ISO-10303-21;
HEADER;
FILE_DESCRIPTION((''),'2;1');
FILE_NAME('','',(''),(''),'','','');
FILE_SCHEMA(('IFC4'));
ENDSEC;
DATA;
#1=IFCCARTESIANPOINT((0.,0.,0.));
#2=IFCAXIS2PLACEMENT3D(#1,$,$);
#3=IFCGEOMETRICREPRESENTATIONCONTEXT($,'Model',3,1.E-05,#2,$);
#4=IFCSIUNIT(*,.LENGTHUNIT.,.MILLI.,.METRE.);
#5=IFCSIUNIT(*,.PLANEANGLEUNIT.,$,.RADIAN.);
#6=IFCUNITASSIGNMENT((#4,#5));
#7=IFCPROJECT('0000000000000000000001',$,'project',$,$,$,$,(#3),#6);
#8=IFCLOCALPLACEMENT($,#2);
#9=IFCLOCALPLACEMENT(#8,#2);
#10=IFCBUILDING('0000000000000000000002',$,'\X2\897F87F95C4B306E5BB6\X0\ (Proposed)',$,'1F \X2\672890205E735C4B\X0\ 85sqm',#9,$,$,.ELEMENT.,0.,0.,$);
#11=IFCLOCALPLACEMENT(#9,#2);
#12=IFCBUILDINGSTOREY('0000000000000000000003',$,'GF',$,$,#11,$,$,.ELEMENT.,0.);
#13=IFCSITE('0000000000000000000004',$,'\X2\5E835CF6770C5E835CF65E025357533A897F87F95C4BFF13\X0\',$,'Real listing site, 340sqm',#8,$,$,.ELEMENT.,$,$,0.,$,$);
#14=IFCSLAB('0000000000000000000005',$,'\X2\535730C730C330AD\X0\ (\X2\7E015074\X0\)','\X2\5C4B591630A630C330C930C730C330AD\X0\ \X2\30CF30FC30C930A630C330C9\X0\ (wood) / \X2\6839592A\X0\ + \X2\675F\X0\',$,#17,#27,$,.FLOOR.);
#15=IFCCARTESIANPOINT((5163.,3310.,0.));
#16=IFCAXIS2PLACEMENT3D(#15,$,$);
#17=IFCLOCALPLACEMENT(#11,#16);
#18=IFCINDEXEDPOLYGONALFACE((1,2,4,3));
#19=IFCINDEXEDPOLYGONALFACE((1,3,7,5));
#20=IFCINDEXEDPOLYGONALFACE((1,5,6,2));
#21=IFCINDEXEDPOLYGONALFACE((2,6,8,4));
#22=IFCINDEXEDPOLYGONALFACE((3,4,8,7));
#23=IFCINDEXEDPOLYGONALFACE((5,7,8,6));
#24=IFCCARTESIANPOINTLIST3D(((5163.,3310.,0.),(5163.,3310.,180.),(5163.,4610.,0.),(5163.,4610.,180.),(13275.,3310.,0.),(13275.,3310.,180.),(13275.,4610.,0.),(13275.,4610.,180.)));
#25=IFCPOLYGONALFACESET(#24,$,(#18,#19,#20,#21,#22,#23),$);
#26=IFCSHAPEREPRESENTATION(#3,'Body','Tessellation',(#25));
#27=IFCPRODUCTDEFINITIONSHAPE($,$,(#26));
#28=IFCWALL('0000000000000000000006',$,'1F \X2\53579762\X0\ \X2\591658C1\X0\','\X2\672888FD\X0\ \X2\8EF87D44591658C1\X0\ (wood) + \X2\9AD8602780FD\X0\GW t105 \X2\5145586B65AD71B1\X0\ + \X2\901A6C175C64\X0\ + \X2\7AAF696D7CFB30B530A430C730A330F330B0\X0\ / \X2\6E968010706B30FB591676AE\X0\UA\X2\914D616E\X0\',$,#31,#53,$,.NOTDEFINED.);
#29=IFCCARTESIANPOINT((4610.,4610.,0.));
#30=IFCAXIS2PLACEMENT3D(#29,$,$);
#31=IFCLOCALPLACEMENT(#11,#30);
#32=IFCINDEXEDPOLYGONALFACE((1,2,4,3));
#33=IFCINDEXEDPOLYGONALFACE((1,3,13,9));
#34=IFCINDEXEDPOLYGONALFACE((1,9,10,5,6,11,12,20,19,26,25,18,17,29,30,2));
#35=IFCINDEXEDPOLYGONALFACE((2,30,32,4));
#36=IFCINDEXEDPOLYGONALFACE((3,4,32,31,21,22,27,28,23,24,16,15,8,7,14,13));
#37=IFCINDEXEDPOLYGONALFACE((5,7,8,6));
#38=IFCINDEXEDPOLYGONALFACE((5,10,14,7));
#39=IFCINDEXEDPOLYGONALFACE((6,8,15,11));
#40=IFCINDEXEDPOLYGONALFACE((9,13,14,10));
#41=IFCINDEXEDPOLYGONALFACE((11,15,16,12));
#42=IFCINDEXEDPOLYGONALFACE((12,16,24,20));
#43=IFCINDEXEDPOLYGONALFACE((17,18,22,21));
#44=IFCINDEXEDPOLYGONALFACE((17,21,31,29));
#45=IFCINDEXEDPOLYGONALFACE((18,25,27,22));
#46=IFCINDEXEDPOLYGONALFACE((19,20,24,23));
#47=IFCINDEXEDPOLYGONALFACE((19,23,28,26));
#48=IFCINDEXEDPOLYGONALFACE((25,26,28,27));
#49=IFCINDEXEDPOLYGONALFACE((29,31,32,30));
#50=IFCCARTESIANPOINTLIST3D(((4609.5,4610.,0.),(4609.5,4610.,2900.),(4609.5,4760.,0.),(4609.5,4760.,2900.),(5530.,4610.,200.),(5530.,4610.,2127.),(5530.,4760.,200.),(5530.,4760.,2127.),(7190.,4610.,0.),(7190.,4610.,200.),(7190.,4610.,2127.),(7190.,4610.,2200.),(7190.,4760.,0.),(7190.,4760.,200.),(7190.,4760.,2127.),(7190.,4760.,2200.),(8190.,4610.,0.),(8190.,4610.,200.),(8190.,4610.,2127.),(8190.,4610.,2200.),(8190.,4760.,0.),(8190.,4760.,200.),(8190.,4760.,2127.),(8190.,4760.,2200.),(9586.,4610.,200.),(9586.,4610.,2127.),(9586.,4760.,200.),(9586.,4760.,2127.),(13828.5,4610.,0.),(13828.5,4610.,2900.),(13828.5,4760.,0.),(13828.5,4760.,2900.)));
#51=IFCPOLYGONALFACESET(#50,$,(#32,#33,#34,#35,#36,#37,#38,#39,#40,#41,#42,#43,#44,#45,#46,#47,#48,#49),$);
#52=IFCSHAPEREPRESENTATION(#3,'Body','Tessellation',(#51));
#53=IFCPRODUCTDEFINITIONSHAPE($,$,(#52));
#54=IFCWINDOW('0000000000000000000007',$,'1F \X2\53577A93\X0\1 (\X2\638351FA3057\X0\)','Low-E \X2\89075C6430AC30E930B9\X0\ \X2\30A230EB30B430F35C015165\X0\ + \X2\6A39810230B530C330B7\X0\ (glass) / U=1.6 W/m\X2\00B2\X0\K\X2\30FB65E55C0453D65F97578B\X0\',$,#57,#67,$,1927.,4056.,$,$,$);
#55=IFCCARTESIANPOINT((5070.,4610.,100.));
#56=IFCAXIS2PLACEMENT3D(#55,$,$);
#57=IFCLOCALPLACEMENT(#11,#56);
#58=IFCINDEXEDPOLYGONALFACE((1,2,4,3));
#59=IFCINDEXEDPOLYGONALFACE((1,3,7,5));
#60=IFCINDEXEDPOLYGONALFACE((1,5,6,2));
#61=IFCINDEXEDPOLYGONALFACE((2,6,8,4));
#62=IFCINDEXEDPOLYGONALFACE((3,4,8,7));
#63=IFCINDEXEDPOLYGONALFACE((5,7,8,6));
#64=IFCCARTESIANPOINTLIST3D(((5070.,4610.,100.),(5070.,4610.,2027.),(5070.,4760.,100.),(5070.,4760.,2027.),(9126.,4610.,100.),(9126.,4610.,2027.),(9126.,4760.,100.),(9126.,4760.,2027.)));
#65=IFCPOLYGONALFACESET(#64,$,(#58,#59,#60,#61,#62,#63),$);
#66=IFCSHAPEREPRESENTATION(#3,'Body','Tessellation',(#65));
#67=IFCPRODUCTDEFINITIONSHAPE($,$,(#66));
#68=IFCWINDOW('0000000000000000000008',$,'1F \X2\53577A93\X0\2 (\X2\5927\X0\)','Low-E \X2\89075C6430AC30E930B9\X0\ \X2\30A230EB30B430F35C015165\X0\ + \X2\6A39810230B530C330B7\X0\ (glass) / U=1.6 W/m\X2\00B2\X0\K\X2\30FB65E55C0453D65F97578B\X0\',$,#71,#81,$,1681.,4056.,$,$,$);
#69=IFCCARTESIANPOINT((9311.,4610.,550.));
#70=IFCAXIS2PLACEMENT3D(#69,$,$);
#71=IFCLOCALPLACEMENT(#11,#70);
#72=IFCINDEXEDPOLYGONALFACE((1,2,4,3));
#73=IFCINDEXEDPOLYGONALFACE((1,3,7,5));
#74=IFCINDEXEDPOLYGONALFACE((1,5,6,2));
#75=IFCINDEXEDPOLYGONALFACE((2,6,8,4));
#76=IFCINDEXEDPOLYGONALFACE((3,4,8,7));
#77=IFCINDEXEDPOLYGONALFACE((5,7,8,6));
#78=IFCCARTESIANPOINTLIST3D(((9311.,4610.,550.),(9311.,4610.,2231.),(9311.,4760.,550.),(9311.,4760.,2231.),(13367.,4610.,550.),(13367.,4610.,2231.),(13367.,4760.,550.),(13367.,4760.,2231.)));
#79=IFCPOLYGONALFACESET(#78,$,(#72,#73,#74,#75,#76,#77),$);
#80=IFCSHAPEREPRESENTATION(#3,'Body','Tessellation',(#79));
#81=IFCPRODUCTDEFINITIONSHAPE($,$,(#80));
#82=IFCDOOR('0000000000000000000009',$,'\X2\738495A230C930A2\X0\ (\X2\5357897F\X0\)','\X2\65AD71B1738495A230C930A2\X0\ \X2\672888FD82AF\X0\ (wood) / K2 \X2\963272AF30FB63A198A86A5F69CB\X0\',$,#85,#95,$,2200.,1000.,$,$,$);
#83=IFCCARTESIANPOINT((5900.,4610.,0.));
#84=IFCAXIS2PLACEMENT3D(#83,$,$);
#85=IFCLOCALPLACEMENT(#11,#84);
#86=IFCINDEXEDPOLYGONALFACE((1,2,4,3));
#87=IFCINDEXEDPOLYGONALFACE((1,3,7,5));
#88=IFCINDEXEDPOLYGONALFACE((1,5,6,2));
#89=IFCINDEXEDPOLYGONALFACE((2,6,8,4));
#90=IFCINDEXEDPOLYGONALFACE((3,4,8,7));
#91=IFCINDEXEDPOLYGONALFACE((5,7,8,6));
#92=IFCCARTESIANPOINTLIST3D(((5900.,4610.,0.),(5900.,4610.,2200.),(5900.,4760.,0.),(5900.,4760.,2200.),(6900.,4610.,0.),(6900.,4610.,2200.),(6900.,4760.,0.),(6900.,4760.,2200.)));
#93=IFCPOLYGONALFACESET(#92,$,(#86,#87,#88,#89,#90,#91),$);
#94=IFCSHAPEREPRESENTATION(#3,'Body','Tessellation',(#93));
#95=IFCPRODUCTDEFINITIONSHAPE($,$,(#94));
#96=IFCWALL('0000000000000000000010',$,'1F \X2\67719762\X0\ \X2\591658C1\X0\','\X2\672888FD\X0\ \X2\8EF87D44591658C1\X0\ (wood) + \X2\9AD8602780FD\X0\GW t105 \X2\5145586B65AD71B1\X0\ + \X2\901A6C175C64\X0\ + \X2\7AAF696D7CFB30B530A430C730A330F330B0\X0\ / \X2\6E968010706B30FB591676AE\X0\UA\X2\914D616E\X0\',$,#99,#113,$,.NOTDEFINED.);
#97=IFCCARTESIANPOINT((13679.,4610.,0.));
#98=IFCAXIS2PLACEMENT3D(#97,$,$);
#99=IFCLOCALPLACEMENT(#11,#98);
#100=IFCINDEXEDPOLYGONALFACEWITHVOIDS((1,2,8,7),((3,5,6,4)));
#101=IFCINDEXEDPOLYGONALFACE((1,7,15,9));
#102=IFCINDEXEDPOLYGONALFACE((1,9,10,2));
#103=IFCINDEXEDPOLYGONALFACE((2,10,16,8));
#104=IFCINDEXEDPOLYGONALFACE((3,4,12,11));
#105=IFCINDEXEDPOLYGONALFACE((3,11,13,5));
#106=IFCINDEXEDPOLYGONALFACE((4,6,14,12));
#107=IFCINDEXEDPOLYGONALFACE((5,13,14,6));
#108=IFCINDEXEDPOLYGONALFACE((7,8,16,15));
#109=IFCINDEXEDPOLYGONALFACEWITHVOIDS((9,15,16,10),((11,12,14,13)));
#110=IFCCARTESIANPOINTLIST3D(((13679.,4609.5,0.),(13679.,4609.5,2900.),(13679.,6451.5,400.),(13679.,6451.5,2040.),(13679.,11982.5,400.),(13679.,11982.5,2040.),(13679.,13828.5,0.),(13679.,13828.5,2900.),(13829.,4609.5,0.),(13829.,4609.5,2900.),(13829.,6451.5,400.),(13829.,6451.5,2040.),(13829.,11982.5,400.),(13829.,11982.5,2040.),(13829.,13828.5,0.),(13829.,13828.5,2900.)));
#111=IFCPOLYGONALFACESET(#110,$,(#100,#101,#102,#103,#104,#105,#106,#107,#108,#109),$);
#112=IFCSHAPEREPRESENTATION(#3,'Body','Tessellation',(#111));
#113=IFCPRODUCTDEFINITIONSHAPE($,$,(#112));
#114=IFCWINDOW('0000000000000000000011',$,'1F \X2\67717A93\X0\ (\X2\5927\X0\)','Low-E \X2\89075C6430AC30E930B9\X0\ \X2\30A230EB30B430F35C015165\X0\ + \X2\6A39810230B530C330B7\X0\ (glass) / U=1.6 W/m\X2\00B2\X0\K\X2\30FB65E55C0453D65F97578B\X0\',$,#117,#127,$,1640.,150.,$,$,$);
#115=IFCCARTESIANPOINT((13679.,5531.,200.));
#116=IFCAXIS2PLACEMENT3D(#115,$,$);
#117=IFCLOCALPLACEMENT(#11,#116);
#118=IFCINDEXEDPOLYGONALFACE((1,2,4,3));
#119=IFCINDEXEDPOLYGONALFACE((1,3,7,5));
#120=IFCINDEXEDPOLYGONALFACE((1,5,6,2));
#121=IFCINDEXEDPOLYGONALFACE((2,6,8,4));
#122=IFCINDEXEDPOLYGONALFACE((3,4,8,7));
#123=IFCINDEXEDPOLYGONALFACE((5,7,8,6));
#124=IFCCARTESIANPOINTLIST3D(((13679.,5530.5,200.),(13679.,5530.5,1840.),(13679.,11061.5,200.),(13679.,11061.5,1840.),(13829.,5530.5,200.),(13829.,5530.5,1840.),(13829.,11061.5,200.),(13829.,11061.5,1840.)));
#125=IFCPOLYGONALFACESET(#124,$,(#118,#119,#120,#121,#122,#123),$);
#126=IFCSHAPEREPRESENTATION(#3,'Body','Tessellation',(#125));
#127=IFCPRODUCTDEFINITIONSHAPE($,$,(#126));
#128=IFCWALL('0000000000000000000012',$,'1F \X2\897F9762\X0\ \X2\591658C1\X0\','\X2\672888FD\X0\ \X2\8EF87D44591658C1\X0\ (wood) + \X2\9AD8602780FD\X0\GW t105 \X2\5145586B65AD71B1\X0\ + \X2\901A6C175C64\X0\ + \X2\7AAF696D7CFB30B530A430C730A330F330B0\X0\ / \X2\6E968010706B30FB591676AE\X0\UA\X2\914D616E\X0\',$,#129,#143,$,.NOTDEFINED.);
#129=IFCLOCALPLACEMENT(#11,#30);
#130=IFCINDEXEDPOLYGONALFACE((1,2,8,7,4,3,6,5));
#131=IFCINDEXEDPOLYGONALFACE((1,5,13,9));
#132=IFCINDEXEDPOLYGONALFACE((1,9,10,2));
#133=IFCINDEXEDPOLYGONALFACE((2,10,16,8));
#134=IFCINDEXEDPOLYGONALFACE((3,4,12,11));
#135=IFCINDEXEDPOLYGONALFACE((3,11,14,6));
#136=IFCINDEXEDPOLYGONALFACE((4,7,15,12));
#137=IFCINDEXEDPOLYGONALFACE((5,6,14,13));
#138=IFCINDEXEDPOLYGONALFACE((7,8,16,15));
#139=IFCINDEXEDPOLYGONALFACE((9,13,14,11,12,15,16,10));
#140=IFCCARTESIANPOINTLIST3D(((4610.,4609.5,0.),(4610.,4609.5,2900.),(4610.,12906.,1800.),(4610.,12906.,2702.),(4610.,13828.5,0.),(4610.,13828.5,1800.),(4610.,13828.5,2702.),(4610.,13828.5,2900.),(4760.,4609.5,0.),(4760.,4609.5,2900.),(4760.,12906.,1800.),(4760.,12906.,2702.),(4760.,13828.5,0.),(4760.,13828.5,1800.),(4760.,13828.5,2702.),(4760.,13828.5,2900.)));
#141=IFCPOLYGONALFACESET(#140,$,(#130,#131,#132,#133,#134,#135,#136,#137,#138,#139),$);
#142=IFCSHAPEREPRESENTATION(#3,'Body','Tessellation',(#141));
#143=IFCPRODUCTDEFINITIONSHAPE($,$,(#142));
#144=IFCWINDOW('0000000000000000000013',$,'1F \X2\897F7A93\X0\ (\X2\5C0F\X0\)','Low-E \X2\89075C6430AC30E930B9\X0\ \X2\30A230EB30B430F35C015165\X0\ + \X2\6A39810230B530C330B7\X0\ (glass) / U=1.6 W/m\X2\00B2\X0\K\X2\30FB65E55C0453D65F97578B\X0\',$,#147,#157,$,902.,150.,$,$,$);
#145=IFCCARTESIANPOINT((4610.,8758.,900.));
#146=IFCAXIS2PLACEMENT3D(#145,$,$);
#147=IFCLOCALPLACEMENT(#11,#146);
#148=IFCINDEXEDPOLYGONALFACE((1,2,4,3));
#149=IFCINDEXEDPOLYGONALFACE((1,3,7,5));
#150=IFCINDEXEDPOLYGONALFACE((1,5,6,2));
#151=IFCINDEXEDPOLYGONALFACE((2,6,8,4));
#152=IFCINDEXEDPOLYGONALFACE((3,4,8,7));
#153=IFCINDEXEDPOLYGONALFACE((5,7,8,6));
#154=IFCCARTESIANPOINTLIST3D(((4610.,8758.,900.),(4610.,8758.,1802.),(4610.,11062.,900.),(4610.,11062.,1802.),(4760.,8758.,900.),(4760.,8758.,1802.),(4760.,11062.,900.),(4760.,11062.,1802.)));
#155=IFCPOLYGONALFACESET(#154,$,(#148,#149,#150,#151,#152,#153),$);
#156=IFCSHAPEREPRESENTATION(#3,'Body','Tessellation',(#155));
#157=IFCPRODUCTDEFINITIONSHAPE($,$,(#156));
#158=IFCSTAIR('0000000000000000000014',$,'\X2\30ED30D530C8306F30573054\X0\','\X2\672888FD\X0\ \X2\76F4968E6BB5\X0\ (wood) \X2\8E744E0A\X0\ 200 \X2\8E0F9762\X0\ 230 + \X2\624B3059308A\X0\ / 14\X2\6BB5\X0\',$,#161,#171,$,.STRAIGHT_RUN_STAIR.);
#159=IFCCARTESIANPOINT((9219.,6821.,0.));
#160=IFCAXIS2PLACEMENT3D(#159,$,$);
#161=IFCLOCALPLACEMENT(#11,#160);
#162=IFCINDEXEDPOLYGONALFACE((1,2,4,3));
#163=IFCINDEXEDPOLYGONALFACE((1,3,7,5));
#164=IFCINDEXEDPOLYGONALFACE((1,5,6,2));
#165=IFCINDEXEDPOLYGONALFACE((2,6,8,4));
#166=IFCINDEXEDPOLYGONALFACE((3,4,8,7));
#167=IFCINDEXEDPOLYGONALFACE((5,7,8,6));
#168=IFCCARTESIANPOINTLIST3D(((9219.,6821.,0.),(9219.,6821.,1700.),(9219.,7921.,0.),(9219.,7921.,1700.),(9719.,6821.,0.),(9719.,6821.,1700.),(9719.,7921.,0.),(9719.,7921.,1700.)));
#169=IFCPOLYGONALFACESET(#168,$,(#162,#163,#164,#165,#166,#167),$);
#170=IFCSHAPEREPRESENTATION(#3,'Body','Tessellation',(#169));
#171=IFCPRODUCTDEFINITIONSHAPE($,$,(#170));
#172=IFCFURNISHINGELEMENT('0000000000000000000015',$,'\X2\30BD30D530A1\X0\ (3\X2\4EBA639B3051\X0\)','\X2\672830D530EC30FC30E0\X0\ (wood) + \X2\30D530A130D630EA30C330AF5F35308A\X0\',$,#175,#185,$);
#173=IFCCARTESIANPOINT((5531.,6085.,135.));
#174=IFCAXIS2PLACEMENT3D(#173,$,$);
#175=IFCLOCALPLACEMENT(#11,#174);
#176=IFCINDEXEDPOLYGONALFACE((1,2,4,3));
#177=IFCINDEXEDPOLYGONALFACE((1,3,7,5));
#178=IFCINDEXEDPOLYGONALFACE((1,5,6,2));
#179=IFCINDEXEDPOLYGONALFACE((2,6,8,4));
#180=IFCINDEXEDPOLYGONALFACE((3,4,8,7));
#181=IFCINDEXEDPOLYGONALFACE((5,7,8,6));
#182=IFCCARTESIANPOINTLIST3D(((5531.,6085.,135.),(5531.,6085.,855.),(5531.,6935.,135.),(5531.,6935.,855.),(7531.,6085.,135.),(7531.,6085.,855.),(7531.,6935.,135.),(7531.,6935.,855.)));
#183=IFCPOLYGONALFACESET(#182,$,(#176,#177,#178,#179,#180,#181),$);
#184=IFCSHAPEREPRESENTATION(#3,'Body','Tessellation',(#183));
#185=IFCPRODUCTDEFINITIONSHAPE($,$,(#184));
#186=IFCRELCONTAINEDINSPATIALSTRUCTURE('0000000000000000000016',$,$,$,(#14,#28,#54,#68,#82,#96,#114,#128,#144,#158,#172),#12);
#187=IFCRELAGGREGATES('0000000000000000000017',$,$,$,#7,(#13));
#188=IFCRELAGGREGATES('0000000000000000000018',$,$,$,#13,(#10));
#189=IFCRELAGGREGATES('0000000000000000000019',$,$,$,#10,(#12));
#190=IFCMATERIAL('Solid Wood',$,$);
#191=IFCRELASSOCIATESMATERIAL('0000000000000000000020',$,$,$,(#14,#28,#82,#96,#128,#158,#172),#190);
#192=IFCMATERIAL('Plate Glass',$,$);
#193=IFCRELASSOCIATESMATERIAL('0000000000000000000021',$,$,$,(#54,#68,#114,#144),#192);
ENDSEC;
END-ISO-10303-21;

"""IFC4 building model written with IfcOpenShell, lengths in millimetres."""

from ifc_helpers import new_model, si_unit, frame, frame_2d, origin, place, context, project, spatial, rectangle, extrude, material, element, fill, save


model = new_model("IFC4")

# Units and contexts
model_context = context("Model", 3, precision=1e-05, world=origin())
ifc_project = project(units=[si_unit("LENGTHUNIT", "METRE", prefix="MILLI"), si_unit("PLANEANGLEUNIT", "RADIAN")], contexts=[model_context])

# Site, building, storey
site_placement = place(None, origin())
site = spatial("IfcSite", under=ifc_project, at=site_placement, Name="広島県広島市南区西蟹屋３", ObjectType="Real listing site, 340sqm", CompositionType="ELEMENT", RefElevation=0.0)
building_placement = place(site_placement, origin())
building = spatial("IfcBuilding", under=site, at=building_placement, Name="西蟹屋の家 (Proposed)", ObjectType="1F 木造平屋 85sqm", CompositionType="ELEMENT", ElevationOfRefHeight=0.0, ElevationOfTerrain=0.0)
storey_placement = place(building_placement, origin())
storey = spatial("IfcBuildingStorey", under=building, at=storey_placement, Name="GF", CompositionType="ELEMENT", Elevation=0.0)

# Slab
ifc_material_1 = material(Name="Solid Wood")
slab_1_placement = place(storey_placement, frame((5163.0, 3310.0, 0.0)))
element("IfcSlab", 1, at=slab_1_placement, inside=storey, material=ifc_material_1, Name="南デッキ (縁側)", Description="屋外ウッドデッキ ハードウッド (wood) / 根太 + 束", PredefinedType="FLOOR", context=model_context, shape_type="SweptSolid", body=[
    extrude(rectangle(XDim=8112.0, YDim=1300.0, at=frame_2d((4056.0, 650.0))), frame((5163.0, 3310.0, 0.0)), (0.0, 0.0, 1.0), 180.0),
])

# Wall, openings, windows, door
wall_1_placement = place(storey_placement, frame((4610.0, 4610.0, 0.0)))
wall_1 = element("IfcWall", 2, at=wall_1_placement, inside=storey, material=ifc_material_1, Name="1F 南面 外壁", Description="木製 軸組外壁 (wood) + 高性能GW t105 充填断熱 + 通気層 + 窯業系サイディング / 準耐火・外皮UA配慮", PredefinedType="NOTDEFINED", context=model_context, shape_type="SweptSolid", body=[
    extrude(rectangle(XDim=9219.0, YDim=150.0, at=frame_2d((4609.0, 75.0))), frame((4610.0, 4610.0, 0.0)), (0.0, 0.0, 1.0), 2900.0),
])
opening_1_placement = place(storey_placement, frame((5070.0, 4610.0, 100.0)))
opening_1 = element("IfcOpeningElement", 3, at=opening_1_placement, cuts=wall_1, PredefinedType="NOTDEFINED", context=model_context, shape_type="SweptSolid", body=[
    extrude(rectangle(XDim=4056.0, YDim=150.0, at=frame_2d((2028.0, 75.0))), frame((5070.0, 4610.0, 100.0)), (0.0, 0.0, 1.0), 1927.0),
])
opening_2_placement = place(storey_placement, frame((9311.0, 4610.0, 550.0)))
opening_2 = element("IfcOpeningElement", 4, at=opening_2_placement, cuts=wall_1, PredefinedType="NOTDEFINED", context=model_context, shape_type="SweptSolid", body=[
    extrude(rectangle(XDim=4056.0, YDim=150.0, at=frame_2d((2028.0, 75.0))), frame((9311.0, 4610.0, 550.0)), (0.0, 0.0, 1.0), 1681.0),
])
opening_3_placement = place(storey_placement, frame((5900.0, 4610.0, 0.0)))
opening_3 = element("IfcOpeningElement", 5, at=opening_3_placement, cuts=wall_1, PredefinedType="NOTDEFINED", context=model_context, shape_type="SweptSolid", body=[
    extrude(rectangle(XDim=1000.0, YDim=150.0, at=frame_2d((500.0, 75.0))), frame((5900.0, 4610.0, 0.0)), (0.0, 0.0, 1.0), 2200.0),
])
ifc_material_2 = material(Name="Plate Glass")
window_1_placement = place(storey_placement, frame((5070.0, 4610.0, 100.0)))
window_1 = element("IfcWindow", 6, at=window_1_placement, inside=storey, material=ifc_material_2, Name="1F 南窓1 (掃出し)", Description="Low-E 複層ガラス アルゴン封入 + 樹脂サッシ (glass) / U=1.6 W/m²K・日射取得型", OverallHeight=1927.0, OverallWidth=4056.0, context=model_context, shape_type="SweptSolid", body=[
    extrude(rectangle(XDim=4056.0, YDim=150.0, at=frame_2d((2028.0, 75.0))), frame((5070.0, 4610.0, 100.0)), (0.0, 0.0, 1.0), 1927.0),
])
fill(opening_1, window_1)
window_2_placement = place(storey_placement, frame((9311.0, 4610.0, 550.0)))
window_2 = element("IfcWindow", 7, at=window_2_placement, inside=storey, material=ifc_material_2, Name="1F 南窓2 (大)", Description="Low-E 複層ガラス アルゴン封入 + 樹脂サッシ (glass) / U=1.6 W/m²K・日射取得型", OverallHeight=1681.0, OverallWidth=4056.0, context=model_context, shape_type="SweptSolid", body=[
    extrude(rectangle(XDim=4056.0, YDim=150.0, at=frame_2d((2028.0, 75.0))), frame((9311.0, 4610.0, 550.0)), (0.0, 0.0, 1.0), 1681.0),
])
fill(opening_2, window_2)
door_placement = place(storey_placement, frame((5900.0, 4610.0, 0.0)))
door = element("IfcDoor", 8, at=door_placement, inside=storey, material=ifc_material_1, Name="玄関ドア (南西)", Description="断熱玄関ドア 木製芯 (wood) / K2 防犯・採風機構", OverallHeight=2200.0, OverallWidth=1000.0, context=model_context, shape_type="SweptSolid", body=[
    extrude(rectangle(XDim=1000.0, YDim=150.0, at=frame_2d((500.0, 75.0))), frame((5900.0, 4610.0, 0.0)), (0.0, 0.0, 1.0), 2200.0),
])
fill(opening_3, door)

# Walls, openings, windows
wall_2_placement = place(storey_placement, frame((13679.0, 4610.0, 0.0)))
wall_2 = element("IfcWall", 9, at=wall_2_placement, inside=storey, material=ifc_material_1, Name="1F 東面 外壁", Description="木製 軸組外壁 (wood) + 高性能GW t105 充填断熱 + 通気層 + 窯業系サイディング / 準耐火・外皮UA配慮", PredefinedType="NOTDEFINED", context=model_context, shape_type="SweptSolid", body=[
    extrude(rectangle(XDim=150.0, YDim=9219.0, at=frame_2d((75.0, 4609.0))), frame((13679.0, 4610.0, 0.0)), (0.0, 0.0, 1.0), 2900.0),
])
opening_4_placement = place(storey_placement, frame((13679.0, 5531.0, 200.0)))
opening_4 = element("IfcOpeningElement", 10, at=opening_4_placement, cuts=wall_2, PredefinedType="NOTDEFINED", context=model_context, shape_type="SweptSolid", body=[
    extrude(rectangle(XDim=150.0, YDim=5531.0, at=frame_2d((75.0, 2765.0))), frame((13679.0, 5531.0, 200.0)), (0.0, 0.0, 1.0), 1640.0),
])
window_3_placement = place(storey_placement, frame((13679.0, 5531.0, 200.0)))
window_3 = element("IfcWindow", 11, at=window_3_placement, inside=storey, material=ifc_material_2, Name="1F 東窓 (大)", Description="Low-E 複層ガラス アルゴン封入 + 樹脂サッシ (glass) / U=1.6 W/m²K・日射取得型", OverallHeight=1640.0, OverallWidth=150.0, context=model_context, shape_type="SweptSolid", body=[
    extrude(rectangle(XDim=150.0, YDim=5531.0, at=frame_2d((75.0, 2765.0))), frame((13679.0, 5531.0, 200.0)), (0.0, 0.0, 1.0), 1640.0),
])
fill(opening_4, window_3)
wall_3_placement = place(storey_placement, frame((4610.0, 4610.0, 0.0)))
wall_3 = element("IfcWall", 12, at=wall_3_placement, inside=storey, material=ifc_material_1, Name="1F 西面 外壁", Description="木製 軸組外壁 (wood) + 高性能GW t105 充填断熱 + 通気層 + 窯業系サイディング / 準耐火・外皮UA配慮", PredefinedType="NOTDEFINED", context=model_context, shape_type="SweptSolid", body=[
    extrude(rectangle(XDim=150.0, YDim=9219.0, at=frame_2d((75.0, 4609.0))), frame((4610.0, 4610.0, 0.0)), (0.0, 0.0, 1.0), 2900.0),
])
opening_5_placement = place(storey_placement, frame((4610.0, 8758.0, 900.0)))
opening_5 = element("IfcOpeningElement", 13, at=opening_5_placement, cuts=wall_3, PredefinedType="NOTDEFINED", context=model_context, shape_type="SweptSolid", body=[
    extrude(rectangle(XDim=150.0, YDim=2304.0, at=frame_2d((75.0, 1152.0))), frame((4610.0, 8758.0, 900.0)), (0.0, 0.0, 1.0), 902.0),
])
window_4_placement = place(storey_placement, frame((4610.0, 8758.0, 900.0)))
window_4 = element("IfcWindow", 14, at=window_4_placement, inside=storey, material=ifc_material_2, Name="1F 西窓 (小)", Description="Low-E 複層ガラス アルゴン封入 + 樹脂サッシ (glass) / U=1.6 W/m²K・日射取得型", OverallHeight=902.0, OverallWidth=150.0, context=model_context, shape_type="SweptSolid", body=[
    extrude(rectangle(XDim=150.0, YDim=2304.0, at=frame_2d((75.0, 1152.0))), frame((4610.0, 8758.0, 900.0)), (0.0, 0.0, 1.0), 902.0),
])
fill(opening_5, window_4)

# Stair
stair_placement = place(storey_placement, frame((9219.0, 6821.0, 0.0)))
element("IfcStair", 15, at=stair_placement, inside=storey, material=ifc_material_1, Name="ロフトはしご", Description="木製 直階段 (wood) 蹴上 200 踏面 230 + 手すり / 14段", PredefinedType="STRAIGHT_RUN_STAIR", context=model_context, shape_type="SweptSolid", body=[
    extrude(rectangle(XDim=500.0, YDim=1100.0, at=frame_2d((250.0, 550.0))), frame((9219.0, 6821.0, 0.0)), (0.0, 0.0, 1.0), 1700.0),
])

# Furnishing element
furnishing_1_placement = place(storey_placement, frame((5531.0, 6085.0, 135.0)))
element("IfcFurnishingElement", 16, at=furnishing_1_placement, inside=storey, material=ifc_material_1, Name="ソファ (3人掛け)", Description="木フレーム (wood) + ファブリック張り", context=model_context, shape_type="SweptSolid", body=[
    extrude(rectangle(XDim=2000.0, YDim=850.0, at=frame_2d((1000.0, 425.0))), frame((5531.0, 6085.0, 135.0)), (0.0, 0.0, 1.0), 720.0),
])

save(model, "model.ifc")
